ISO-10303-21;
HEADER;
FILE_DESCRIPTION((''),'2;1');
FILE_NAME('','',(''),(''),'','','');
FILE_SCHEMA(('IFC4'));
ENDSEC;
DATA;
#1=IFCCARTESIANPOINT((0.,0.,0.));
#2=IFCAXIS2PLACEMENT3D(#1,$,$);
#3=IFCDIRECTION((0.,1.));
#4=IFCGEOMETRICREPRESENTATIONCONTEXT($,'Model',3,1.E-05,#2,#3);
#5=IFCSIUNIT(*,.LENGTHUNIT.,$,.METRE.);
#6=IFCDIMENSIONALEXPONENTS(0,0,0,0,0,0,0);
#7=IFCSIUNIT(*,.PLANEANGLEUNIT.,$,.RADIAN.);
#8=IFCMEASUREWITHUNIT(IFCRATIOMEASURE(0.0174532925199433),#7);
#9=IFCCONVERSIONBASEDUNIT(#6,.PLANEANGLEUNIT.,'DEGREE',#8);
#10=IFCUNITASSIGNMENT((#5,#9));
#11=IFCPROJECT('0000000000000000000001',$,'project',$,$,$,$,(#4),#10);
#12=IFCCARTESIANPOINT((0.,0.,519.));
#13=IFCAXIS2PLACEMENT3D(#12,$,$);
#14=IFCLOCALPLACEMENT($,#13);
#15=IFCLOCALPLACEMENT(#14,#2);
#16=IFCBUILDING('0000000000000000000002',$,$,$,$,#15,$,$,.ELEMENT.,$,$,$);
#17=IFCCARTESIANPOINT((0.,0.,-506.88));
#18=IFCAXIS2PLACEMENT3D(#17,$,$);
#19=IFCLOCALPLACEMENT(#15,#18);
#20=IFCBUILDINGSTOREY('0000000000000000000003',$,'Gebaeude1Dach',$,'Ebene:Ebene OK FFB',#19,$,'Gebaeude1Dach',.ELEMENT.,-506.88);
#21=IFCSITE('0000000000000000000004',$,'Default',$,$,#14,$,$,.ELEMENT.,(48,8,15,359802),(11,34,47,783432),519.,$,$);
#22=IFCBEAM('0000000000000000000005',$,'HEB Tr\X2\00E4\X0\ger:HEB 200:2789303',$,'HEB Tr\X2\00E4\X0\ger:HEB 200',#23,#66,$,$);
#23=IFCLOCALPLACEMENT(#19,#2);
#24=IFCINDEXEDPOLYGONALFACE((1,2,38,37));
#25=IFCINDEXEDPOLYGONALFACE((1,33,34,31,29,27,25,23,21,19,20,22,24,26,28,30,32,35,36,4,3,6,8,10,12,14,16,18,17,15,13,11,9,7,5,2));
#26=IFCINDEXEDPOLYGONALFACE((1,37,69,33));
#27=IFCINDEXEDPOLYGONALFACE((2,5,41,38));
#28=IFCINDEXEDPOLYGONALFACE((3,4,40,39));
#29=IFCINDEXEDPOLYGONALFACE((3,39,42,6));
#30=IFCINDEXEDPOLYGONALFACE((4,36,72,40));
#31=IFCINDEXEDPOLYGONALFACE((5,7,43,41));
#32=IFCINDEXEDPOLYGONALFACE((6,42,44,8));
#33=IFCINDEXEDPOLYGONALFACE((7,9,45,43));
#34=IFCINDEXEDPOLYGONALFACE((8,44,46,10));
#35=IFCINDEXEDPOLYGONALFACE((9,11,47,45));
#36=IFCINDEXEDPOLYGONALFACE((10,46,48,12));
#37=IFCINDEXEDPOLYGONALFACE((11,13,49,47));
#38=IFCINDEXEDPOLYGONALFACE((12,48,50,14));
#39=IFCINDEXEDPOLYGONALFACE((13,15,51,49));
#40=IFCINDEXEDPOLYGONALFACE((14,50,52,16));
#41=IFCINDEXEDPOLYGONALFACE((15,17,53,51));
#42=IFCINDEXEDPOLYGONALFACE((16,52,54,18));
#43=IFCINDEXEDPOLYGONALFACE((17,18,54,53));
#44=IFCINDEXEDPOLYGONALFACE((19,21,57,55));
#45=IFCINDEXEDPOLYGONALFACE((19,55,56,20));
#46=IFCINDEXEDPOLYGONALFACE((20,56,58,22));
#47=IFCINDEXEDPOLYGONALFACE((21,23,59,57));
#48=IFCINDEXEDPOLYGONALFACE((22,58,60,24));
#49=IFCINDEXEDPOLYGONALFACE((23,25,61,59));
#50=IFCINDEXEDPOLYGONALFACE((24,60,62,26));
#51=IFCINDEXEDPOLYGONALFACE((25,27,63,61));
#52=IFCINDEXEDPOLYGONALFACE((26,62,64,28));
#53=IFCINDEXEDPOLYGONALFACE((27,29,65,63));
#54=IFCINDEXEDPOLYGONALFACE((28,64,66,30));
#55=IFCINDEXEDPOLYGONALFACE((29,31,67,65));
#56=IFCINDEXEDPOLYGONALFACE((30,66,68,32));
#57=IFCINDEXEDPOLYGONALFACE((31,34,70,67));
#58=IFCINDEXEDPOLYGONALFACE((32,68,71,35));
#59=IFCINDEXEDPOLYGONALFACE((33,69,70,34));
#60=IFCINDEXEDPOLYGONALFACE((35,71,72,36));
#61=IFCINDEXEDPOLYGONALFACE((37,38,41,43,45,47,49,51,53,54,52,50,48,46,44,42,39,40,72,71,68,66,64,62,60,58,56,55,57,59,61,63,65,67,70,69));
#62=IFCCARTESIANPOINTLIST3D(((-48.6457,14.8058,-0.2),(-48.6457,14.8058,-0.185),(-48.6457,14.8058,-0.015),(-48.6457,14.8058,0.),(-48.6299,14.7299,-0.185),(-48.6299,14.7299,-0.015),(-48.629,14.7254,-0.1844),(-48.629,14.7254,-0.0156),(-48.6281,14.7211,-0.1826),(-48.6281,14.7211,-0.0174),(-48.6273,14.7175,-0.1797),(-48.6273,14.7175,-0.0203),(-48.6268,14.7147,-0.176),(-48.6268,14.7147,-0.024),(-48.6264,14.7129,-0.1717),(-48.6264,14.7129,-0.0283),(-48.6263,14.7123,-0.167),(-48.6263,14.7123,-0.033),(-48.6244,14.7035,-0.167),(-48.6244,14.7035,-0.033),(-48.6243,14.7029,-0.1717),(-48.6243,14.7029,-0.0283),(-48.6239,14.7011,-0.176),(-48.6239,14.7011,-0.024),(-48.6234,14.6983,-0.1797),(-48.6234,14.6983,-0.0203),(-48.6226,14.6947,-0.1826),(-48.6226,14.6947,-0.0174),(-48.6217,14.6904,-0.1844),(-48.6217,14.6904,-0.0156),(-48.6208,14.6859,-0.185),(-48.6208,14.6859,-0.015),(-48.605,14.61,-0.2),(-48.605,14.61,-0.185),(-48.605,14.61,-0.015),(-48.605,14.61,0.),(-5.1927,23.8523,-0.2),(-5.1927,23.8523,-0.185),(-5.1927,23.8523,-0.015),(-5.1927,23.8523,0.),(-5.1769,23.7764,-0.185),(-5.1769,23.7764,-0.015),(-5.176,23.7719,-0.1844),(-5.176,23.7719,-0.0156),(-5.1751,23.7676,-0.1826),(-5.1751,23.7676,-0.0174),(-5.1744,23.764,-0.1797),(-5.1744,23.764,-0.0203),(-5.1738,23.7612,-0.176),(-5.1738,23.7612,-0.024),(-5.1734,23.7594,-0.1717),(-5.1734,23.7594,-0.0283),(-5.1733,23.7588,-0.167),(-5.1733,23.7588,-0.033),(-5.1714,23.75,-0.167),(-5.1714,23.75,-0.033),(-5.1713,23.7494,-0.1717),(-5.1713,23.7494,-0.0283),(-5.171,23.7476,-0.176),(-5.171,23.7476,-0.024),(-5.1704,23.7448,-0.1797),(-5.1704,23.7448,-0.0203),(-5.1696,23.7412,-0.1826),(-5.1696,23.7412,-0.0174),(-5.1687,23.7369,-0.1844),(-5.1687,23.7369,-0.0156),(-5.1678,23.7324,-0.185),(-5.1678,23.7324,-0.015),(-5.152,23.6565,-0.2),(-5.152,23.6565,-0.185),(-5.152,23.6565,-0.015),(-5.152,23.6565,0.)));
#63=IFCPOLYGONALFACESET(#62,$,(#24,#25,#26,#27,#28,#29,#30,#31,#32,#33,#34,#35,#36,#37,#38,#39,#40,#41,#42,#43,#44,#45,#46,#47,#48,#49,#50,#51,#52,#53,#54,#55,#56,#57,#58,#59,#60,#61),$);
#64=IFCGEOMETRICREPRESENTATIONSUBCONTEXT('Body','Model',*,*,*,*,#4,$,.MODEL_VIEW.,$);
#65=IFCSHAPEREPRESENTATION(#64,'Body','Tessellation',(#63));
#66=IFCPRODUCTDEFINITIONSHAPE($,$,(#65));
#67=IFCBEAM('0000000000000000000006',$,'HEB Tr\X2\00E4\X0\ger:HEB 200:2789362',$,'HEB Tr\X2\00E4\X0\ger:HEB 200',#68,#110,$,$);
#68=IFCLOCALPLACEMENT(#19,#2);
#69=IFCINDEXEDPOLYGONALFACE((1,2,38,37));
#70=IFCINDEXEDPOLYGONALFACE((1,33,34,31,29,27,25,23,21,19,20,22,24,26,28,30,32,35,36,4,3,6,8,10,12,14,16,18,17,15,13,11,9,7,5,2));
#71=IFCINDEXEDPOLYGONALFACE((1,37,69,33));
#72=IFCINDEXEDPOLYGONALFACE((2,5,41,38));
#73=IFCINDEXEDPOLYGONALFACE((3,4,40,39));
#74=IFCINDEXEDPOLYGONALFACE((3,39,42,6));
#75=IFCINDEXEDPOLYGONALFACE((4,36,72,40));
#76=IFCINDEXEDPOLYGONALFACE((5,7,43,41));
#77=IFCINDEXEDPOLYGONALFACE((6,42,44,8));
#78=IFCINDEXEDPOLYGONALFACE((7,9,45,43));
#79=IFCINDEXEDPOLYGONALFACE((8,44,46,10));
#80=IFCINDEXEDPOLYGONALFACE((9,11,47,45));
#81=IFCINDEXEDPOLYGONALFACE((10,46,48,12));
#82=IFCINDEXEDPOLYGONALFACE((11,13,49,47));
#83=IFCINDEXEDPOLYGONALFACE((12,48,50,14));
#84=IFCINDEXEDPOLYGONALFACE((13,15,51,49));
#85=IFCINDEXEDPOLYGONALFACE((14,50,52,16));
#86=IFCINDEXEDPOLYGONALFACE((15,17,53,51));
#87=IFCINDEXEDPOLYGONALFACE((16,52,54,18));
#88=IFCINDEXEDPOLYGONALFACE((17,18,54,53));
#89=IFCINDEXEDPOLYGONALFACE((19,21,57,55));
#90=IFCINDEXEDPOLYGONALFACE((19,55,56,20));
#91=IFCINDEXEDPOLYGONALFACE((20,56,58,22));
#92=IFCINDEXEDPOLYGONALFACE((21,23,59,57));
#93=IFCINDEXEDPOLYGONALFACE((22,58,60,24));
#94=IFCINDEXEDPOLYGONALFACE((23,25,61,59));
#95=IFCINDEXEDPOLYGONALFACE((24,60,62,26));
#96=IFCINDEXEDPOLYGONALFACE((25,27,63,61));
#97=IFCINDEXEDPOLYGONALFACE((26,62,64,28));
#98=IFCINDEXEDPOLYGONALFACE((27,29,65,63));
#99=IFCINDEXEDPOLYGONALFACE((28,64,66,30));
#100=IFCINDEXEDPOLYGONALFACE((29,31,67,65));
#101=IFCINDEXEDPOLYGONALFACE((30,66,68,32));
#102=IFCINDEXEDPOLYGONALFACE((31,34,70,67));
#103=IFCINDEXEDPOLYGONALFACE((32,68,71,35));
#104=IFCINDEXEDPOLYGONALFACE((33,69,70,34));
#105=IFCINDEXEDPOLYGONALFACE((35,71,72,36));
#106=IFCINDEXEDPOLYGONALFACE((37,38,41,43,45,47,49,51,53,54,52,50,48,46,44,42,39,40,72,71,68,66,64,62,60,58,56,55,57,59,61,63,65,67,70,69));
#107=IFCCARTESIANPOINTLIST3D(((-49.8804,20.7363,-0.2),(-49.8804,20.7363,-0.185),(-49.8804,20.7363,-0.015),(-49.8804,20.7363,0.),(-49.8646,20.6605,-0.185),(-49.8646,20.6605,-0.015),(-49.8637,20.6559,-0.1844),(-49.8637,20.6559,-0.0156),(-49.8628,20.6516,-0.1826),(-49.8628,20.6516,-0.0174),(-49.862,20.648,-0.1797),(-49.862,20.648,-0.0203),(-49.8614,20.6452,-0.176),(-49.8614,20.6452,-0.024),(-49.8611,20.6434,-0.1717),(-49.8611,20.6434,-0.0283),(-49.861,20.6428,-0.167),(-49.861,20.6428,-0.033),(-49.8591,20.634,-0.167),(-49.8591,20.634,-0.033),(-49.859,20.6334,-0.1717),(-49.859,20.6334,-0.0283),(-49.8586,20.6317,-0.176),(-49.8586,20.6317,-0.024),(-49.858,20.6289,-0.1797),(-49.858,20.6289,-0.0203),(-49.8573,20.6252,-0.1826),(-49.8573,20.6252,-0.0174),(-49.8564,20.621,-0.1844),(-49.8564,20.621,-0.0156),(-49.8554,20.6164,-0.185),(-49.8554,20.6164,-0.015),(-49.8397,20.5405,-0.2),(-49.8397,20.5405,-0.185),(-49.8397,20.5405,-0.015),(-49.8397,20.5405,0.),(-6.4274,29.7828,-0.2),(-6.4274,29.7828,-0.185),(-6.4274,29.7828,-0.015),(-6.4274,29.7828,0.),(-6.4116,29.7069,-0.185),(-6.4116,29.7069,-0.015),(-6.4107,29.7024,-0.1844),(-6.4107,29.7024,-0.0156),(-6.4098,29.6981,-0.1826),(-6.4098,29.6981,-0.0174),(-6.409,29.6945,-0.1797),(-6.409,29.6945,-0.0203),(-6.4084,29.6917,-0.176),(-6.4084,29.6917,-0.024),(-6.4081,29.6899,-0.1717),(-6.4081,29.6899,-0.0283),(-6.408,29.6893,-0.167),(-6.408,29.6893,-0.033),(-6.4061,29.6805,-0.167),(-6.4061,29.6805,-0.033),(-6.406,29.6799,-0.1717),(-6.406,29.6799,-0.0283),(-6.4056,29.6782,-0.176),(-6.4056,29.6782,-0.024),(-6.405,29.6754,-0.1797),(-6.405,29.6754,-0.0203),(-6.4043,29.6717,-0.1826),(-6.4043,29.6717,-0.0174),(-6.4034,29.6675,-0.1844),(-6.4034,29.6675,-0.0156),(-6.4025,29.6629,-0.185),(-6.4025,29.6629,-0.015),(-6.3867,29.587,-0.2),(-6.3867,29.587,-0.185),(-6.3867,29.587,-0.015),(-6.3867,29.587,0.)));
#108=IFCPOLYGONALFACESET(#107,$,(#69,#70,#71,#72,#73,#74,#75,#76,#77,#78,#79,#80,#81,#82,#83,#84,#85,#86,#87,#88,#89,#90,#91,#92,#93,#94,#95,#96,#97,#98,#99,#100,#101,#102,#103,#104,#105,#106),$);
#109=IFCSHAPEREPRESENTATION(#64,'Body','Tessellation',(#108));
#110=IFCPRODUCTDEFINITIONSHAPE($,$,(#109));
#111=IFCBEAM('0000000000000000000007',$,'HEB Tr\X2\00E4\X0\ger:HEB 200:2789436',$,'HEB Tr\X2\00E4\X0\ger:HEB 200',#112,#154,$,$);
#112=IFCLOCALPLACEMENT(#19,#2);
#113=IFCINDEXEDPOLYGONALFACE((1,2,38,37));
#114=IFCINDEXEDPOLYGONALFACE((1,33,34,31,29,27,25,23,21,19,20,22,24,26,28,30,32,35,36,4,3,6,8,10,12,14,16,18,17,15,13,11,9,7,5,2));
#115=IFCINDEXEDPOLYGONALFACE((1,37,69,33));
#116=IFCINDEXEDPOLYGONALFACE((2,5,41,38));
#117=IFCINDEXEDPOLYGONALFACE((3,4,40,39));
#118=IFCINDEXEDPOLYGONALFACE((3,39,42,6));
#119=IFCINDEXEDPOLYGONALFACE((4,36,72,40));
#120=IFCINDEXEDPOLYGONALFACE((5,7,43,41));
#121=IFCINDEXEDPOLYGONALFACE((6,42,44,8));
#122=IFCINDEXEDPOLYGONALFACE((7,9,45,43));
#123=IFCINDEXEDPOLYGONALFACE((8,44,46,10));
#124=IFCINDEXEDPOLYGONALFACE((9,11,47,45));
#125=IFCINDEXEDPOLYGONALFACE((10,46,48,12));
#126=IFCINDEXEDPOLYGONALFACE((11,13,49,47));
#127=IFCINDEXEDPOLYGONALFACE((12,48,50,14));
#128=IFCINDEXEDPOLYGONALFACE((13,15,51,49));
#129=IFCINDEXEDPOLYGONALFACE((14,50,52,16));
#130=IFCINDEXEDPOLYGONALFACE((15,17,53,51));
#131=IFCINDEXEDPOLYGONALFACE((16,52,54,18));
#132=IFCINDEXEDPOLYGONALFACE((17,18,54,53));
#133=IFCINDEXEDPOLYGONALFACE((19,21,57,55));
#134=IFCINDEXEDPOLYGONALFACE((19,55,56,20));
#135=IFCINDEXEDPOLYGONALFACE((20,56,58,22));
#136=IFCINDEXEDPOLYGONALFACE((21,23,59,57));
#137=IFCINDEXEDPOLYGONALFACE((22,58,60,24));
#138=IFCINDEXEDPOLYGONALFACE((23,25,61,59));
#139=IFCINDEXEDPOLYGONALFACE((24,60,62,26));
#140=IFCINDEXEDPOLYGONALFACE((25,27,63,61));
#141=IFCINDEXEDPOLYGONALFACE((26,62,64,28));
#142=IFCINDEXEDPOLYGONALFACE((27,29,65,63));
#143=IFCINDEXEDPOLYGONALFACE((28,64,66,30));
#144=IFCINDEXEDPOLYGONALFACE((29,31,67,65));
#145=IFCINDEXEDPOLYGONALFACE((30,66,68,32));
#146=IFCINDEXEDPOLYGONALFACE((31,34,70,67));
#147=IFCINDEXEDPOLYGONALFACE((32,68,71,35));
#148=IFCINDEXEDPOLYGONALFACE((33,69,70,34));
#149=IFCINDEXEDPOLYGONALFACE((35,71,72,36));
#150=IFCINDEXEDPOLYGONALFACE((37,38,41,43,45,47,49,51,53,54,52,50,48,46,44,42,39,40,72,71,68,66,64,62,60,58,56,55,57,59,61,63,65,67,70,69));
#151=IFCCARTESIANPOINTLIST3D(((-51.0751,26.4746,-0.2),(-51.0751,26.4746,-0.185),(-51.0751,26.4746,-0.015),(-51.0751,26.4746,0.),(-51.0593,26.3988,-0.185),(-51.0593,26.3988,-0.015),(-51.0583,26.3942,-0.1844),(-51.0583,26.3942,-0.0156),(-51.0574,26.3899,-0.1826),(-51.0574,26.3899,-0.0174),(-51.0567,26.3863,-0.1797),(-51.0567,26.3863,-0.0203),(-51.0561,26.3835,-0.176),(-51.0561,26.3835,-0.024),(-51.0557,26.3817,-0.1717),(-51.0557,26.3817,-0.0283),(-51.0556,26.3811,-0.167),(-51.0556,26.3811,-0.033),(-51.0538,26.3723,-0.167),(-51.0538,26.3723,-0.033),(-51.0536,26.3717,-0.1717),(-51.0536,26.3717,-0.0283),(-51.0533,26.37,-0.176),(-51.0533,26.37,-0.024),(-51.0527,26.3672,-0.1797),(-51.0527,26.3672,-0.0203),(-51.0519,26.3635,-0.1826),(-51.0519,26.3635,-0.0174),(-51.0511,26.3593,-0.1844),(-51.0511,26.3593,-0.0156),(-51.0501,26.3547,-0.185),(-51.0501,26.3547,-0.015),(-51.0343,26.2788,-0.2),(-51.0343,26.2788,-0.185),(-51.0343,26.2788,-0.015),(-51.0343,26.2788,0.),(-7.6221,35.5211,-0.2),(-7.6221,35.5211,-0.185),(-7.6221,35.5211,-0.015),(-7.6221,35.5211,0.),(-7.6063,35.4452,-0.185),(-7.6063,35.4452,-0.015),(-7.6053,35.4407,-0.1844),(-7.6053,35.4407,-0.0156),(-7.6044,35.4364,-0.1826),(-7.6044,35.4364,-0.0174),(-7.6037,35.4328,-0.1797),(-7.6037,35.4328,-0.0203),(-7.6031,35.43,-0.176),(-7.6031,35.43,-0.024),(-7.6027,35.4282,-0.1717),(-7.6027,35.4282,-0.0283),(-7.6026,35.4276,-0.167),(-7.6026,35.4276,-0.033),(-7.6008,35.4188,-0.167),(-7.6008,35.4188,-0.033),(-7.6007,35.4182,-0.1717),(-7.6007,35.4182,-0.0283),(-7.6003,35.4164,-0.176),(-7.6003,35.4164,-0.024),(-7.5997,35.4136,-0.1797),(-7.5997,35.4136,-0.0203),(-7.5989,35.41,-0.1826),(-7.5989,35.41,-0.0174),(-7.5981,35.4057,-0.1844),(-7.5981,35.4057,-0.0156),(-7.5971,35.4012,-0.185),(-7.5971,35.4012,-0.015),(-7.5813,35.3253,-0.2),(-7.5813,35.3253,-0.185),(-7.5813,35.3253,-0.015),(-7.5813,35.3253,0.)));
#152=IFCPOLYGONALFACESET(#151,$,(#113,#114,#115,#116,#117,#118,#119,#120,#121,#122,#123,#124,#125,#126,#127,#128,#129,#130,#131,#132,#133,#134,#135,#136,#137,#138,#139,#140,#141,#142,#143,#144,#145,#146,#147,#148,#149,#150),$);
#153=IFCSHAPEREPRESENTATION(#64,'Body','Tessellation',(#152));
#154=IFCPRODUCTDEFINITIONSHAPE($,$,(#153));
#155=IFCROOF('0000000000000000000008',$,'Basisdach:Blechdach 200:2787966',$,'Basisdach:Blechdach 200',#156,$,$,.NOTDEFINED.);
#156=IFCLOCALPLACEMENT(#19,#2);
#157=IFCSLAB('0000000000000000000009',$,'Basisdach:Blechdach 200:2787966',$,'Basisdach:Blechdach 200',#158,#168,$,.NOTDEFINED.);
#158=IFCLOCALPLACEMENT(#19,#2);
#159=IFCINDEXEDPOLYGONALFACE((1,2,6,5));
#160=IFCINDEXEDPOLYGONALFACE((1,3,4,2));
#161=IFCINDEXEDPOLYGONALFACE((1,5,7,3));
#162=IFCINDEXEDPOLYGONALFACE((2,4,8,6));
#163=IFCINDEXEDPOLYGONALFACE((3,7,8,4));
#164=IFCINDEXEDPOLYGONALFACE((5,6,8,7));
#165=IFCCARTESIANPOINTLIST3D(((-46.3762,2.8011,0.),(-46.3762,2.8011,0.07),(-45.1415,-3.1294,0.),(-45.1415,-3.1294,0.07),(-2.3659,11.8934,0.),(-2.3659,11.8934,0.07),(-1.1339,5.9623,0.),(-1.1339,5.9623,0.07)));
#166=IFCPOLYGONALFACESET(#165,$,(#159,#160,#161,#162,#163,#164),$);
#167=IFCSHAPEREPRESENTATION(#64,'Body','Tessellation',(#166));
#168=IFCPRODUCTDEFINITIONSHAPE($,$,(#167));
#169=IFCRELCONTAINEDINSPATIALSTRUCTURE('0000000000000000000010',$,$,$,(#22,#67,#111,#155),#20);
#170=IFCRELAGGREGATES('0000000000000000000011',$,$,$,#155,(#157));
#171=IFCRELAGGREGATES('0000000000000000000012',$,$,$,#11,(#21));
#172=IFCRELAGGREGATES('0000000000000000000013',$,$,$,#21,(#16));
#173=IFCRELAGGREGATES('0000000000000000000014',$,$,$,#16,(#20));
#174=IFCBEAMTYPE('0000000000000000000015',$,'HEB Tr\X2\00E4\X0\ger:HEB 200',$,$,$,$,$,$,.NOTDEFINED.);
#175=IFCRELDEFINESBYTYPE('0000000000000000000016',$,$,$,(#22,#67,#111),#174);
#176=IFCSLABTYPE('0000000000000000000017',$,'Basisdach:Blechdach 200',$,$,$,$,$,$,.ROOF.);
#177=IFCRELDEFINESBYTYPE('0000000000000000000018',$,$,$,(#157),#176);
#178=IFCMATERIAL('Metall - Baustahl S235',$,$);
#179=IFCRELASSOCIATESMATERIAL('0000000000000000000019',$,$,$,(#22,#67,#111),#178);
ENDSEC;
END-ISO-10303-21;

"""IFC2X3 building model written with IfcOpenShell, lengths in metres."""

from ifc_helpers import new_model, entity, si_unit, converted_unit, direction, frame, frame_2d, origin, place, context, subcontext, project, spatial, polyline, i_section, outline, extrude, material, type_object, element, aggregate, save


model = new_model("IFC2X3")

# Units and contexts
model_context = context("Model", 3, precision=1e-05, world=origin(), true_north=direction((0.0, 1.0)))
body_context = subcontext(model_context, "Body", "Model", "MODEL_VIEW")
ifc_project = project(units=[si_unit("LENGTHUNIT", "METRE"), converted_unit("PLANEANGLEUNIT", "DEGREE", entity("IfcRatioMeasure", 0.0174532925199433), si_unit("PLANEANGLEUNIT", "RADIAN"), dimensions=[0, 0, 0, 0, 0, 0, 0])], contexts=[model_context])

# Site, building, storey
site_placement = place(None, frame((0.0, 0.0, 519.0)))
site = spatial("IfcSite", under=ifc_project, at=site_placement, Name="Default", CompositionType="ELEMENT", RefLatitude=(48, 8, 15, 359802), RefLongitude=(11, 34, 47, 783432), RefElevation=519.0)
building_placement = place(site_placement, origin())
building = spatial("IfcBuilding", under=site, at=building_placement, CompositionType="ELEMENT")
storey_placement = place(building_placement, frame((0.0, 0.0, -506.88)))
storey = spatial("IfcBuildingStorey", under=building, at=storey_placement, Name="Gebaeude1Dach", ObjectType="Ebene:Ebene OK FFB", LongName="Gebaeude1Dach", CompositionType="ELEMENT", Elevation=-506.88)

# Beams
ifc_material = material(Name="Metall - Baustahl S235")
beam_type = type_object("IfcBeamType", Name="HEB Träger:HEB 200", PredefinedType="NOTDEFINED")
beam_1_placement = place(storey_placement, frame((-5.059, 23.778, 0.0), z_axis=(0.0, 0.0, 1.0), x_axis=(-0.979008, -0.20382, 0.0)))
element("IfcBeam", 1, at=beam_1_placement, inside=storey, type_object=beam_type, material=ifc_material, Name="HEB Träger:HEB 200:2789303", ObjectType="HEB Träger:HEB 200", context=body_context, shape_type="SweptSolid", body=[
    extrude(i_section(OverallWidth=0.2, OverallDepth=0.2, WebThickness=0.009, FlangeThickness=0.015, FilletRadius=0.018, at=frame_2d((0.0, 0.0), x_axis=(0.0, 1.0))), frame((0.1157, 0.0, -0.1), z_axis=(1.0, 0.0, 0.0), x_axis=(0.0, 0.0, -1.0)), (0.0, 0.0, 1.0), 44.3847),
])
beam_2_placement = place(storey_placement, frame((-6.2937, 29.7085, 0.0), z_axis=(0.0, 0.0, 1.0), x_axis=(-0.979008, -0.20382, 0.0)))
element("IfcBeam", 2, at=beam_2_placement, inside=storey, type_object=beam_type, material=ifc_material, Name="HEB Träger:HEB 200:2789362", ObjectType="HEB Träger:HEB 200", context=body_context, shape_type="SweptSolid", body=[
    extrude(i_section(OverallWidth=0.2, OverallDepth=0.2, WebThickness=0.009, FlangeThickness=0.015, FilletRadius=0.018, at=frame_2d((0.0, 0.0), x_axis=(0.0, 1.0))), frame((0.1157, 0.0, -0.1), z_axis=(1.0, 0.0, 0.0), x_axis=(0.0, 0.0, -1.0)), (0.0, 0.0, 1.0), 44.3847),
])
beam_3_placement = place(storey_placement, frame((-7.4884, 35.4468, 0.0), z_axis=(0.0, 0.0, 1.0), x_axis=(-0.979008, -0.20382, 0.0)))
element("IfcBeam", 3, at=beam_3_placement, inside=storey, type_object=beam_type, material=ifc_material, Name="HEB Träger:HEB 200:2789436", ObjectType="HEB Träger:HEB 200", context=body_context, shape_type="SweptSolid", body=[
    extrude(i_section(OverallWidth=0.2, OverallDepth=0.2, WebThickness=0.009, FlangeThickness=0.015, FilletRadius=0.018, at=frame_2d((0.0, 0.0), x_axis=(0.0, 1.0))), frame((0.1157, 0.0, -0.1), z_axis=(1.0, 0.0, 0.0), x_axis=(0.0, 0.0, -1.0)), (0.0, 0.0, 1.0), 44.3847),
])

# Roof, slab
roof_1_placement = place(storey_placement, frame((-46.3762, -3.1294, 0.0)))
roof_1 = element("IfcRoof", 4, at=roof_1_placement, inside=storey, Name="Basisdach:Blechdach 200:2787966", ObjectType="Basisdach:Blechdach 200", ShapeType="NOTDEFINED")
slab_type_1 = type_object("IfcSlabType", Name="Basisdach:Blechdach 200", PredefinedType="ROOF")
slab_1_placement = place(roof_1_placement, origin())
slab_1 = element("IfcSlab", 5, at=slab_1_placement, type_object=slab_type_1, Name="Basisdach:Blechdach 200:2787966", ObjectType="Basisdach:Blechdach 200", PredefinedType="NOTDEFINED", context=body_context, shape_type="SweptSolid", body=[
    extrude(outline(polyline([(-22.6212, -1.5808), (-21.3865, -7.5114), (22.6212, 1.5803), (21.3892, 7.5114), (-22.6212, -1.5808)])), frame((22.6212, 7.5114, 0.0)), (0.0, 0.0, 1.0), 0.07),
])
aggregate(roof_1, [slab_1])

save(model, "model.ifc")
